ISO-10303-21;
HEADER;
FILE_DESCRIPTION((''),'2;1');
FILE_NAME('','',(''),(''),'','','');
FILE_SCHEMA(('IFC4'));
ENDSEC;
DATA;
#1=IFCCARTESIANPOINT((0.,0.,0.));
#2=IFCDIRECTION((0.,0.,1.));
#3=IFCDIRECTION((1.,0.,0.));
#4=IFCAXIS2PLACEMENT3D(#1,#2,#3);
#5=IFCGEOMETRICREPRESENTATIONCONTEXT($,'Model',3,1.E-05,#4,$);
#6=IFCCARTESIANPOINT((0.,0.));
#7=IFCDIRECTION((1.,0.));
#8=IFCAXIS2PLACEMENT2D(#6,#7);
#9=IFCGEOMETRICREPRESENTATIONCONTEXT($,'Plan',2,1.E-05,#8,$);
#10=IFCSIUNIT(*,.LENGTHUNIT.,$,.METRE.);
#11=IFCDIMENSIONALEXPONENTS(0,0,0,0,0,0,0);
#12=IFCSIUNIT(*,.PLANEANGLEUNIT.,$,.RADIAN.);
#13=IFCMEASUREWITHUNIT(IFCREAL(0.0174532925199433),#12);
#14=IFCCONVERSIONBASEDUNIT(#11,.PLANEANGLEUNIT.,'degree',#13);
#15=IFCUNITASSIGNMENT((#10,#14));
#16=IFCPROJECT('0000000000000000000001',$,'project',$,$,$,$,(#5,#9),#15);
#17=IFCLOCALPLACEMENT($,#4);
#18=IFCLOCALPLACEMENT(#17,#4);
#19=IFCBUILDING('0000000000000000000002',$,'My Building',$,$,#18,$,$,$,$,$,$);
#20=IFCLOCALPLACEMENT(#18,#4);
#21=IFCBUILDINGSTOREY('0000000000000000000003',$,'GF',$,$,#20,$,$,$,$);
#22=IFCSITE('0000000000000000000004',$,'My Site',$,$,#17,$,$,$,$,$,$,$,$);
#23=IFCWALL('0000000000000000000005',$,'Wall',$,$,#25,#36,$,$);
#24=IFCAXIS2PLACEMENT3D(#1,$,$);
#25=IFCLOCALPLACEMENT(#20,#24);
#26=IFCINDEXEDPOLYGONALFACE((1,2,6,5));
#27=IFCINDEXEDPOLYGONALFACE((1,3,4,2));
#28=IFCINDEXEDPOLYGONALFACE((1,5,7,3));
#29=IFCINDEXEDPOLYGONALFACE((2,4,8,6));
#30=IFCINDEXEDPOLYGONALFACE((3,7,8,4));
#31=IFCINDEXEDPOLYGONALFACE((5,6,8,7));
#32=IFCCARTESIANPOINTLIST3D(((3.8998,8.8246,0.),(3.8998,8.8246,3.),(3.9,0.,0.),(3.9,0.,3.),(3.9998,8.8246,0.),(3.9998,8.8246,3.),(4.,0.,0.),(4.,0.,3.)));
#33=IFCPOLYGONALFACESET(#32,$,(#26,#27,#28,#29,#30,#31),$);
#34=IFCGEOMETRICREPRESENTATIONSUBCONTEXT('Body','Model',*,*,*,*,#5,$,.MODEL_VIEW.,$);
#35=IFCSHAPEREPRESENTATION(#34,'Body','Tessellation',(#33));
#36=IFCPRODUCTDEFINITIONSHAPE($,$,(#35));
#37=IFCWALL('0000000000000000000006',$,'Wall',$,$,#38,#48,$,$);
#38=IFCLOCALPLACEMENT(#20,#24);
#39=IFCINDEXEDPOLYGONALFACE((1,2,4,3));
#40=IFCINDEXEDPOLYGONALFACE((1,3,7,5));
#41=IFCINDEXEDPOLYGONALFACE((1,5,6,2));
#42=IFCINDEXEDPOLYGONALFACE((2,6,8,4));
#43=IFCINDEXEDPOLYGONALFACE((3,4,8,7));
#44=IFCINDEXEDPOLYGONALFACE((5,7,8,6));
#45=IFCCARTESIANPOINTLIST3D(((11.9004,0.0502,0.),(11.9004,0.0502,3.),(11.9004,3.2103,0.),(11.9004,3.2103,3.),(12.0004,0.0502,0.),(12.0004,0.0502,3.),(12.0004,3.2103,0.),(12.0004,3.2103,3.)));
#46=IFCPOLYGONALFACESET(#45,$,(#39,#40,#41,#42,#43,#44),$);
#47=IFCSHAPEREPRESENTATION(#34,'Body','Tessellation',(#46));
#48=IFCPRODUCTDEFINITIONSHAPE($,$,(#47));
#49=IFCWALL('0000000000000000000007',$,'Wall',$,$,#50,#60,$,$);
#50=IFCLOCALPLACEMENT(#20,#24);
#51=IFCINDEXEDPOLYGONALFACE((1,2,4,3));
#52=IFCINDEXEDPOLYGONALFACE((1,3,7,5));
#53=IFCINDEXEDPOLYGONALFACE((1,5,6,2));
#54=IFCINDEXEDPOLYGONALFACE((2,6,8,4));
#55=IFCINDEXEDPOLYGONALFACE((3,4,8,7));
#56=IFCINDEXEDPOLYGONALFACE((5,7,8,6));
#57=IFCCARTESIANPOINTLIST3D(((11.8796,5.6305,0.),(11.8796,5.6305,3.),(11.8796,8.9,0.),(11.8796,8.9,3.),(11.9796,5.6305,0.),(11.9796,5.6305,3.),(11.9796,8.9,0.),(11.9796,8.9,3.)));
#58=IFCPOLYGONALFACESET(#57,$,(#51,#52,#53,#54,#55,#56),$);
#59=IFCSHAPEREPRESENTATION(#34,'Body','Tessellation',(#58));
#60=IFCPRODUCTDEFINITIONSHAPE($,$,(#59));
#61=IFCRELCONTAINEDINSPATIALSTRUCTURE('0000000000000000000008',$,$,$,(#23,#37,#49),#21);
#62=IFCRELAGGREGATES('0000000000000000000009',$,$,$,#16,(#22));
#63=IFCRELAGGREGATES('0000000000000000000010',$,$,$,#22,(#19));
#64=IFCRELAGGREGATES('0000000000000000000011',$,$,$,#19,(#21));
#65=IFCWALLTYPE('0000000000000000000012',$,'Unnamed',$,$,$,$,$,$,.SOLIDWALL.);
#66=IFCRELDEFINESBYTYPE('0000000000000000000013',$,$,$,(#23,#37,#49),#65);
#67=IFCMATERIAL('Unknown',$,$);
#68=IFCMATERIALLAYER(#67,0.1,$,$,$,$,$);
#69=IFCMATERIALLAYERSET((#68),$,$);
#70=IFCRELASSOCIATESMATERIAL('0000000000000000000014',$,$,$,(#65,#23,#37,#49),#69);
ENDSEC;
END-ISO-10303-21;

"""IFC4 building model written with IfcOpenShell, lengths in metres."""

from ifc_helpers import new_model, entity, si_unit, converted_unit, frame, origin_with_axes, origin_2d_with_axis, place, context, subcontext, project, spatial, line, indexed_curve, outline, extrude, material, layer, layer_set, layer_usage, type_object, element, save


model = new_model("IFC4")

# Units and contexts
model_context = context("Model", 3, precision=1e-05, world=origin_with_axes())
plan_context = context("Plan", 2, precision=1e-05, world=origin_2d_with_axis())
body_context_1 = subcontext(model_context, "Body", "Model", "MODEL_VIEW")
ifc_project = project(units=[si_unit("LENGTHUNIT", "METRE"), converted_unit("PLANEANGLEUNIT", "degree", entity("IfcReal", 0.0174532925199433), si_unit("PLANEANGLEUNIT", "RADIAN"), dimensions=[0, 0, 0, 0, 0, 0, 0])], contexts=[model_context, plan_context])

# Site, building, storey
site_placement = place(None, origin_with_axes())
site = spatial("IfcSite", under=ifc_project, at=site_placement, Name="My Site")
building_placement = place(site_placement, origin_with_axes())
building = spatial("IfcBuilding", under=site, at=building_placement, Name="My Building")
storey_placement = place(building_placement, origin_with_axes())
storey = spatial("IfcBuildingStorey", under=building, at=storey_placement, Name="GF")

# Shared definitions
ifc_material = material(Name="Unknown")
ifc_layer = layer(ifc_material, 0.1)
ifc_layer_set = layer_set([ifc_layer])
wall_type = type_object("IfcWallType", Name="Unnamed", PredefinedType="SOLIDWALL", material=ifc_layer_set)

# Walls
ifc_layer_usage_1 = layer_usage(ifc_layer_set, "AXIS2", "POSITIVE", 0.0)
wall_1_placement = place(storey_placement, frame((4.0, 0.0, 0.0), z_axis=(0.0, 0.0, 1.0), x_axis=(-0.000021, 1.0, 0.0)))
element("IfcWall", 1, at=wall_1_placement, inside=storey, type_object=wall_type, material=ifc_layer_usage_1, Name="Wall", context=body_context_1, shape_type="SweptSolid", body=[
    extrude(outline(indexed_curve([(0.0, 0.0), (0.0, 0.1), (8.8246, 0.1), (8.8246, 0.0)], segments=[line(1, 2, 3, 4, 1)])), origin_with_axes(), (0.0, 0.0, 1.0), 3.0),
])
ifc_layer_usage_2 = layer_usage(ifc_layer_set, "AXIS2", "POSITIVE", 0.0)
wall_2_placement = place(storey_placement, frame((12.0004, 0.0502, 0.0), z_axis=(0.0, 0.0, 1.0), x_axis=(0.000013, 1.0, 0.0)))
element("IfcWall", 2, at=wall_2_placement, inside=storey, type_object=wall_type, material=ifc_layer_usage_2, Name="Wall", context=body_context_1, shape_type="SweptSolid", body=[
    extrude(outline(indexed_curve([(0.0, 0.0), (0.0, 0.1), (3.1602, 0.1), (3.1602, 0.0)], segments=[line(1, 2, 3, 4, 1)])), origin_with_axes(), (0.0, 0.0, 1.0), 3.0),
])
ifc_layer_usage_3 = layer_usage(ifc_layer_set, "AXIS2", "POSITIVE", 0.0)
wall_3_placement = place(storey_placement, frame((11.9796, 5.6305, 0.0), z_axis=(0.0, 0.0, 1.0), x_axis=(0.0, 1.0, 0.0)))
element("IfcWall", 3, at=wall_3_placement, inside=storey, type_object=wall_type, material=ifc_layer_usage_3, Name="Wall", context=body_context_1, shape_type="SweptSolid", body=[
    extrude(outline(indexed_curve([(0.0, 0.0), (0.0, 0.1), (3.2695, 0.1), (3.2695, 0.0)], segments=[line(1, 2, 3, 4, 1)])), origin_with_axes(), (0.0, 0.0, 1.0), 3.0),
])

save(model, "model.ifc")
